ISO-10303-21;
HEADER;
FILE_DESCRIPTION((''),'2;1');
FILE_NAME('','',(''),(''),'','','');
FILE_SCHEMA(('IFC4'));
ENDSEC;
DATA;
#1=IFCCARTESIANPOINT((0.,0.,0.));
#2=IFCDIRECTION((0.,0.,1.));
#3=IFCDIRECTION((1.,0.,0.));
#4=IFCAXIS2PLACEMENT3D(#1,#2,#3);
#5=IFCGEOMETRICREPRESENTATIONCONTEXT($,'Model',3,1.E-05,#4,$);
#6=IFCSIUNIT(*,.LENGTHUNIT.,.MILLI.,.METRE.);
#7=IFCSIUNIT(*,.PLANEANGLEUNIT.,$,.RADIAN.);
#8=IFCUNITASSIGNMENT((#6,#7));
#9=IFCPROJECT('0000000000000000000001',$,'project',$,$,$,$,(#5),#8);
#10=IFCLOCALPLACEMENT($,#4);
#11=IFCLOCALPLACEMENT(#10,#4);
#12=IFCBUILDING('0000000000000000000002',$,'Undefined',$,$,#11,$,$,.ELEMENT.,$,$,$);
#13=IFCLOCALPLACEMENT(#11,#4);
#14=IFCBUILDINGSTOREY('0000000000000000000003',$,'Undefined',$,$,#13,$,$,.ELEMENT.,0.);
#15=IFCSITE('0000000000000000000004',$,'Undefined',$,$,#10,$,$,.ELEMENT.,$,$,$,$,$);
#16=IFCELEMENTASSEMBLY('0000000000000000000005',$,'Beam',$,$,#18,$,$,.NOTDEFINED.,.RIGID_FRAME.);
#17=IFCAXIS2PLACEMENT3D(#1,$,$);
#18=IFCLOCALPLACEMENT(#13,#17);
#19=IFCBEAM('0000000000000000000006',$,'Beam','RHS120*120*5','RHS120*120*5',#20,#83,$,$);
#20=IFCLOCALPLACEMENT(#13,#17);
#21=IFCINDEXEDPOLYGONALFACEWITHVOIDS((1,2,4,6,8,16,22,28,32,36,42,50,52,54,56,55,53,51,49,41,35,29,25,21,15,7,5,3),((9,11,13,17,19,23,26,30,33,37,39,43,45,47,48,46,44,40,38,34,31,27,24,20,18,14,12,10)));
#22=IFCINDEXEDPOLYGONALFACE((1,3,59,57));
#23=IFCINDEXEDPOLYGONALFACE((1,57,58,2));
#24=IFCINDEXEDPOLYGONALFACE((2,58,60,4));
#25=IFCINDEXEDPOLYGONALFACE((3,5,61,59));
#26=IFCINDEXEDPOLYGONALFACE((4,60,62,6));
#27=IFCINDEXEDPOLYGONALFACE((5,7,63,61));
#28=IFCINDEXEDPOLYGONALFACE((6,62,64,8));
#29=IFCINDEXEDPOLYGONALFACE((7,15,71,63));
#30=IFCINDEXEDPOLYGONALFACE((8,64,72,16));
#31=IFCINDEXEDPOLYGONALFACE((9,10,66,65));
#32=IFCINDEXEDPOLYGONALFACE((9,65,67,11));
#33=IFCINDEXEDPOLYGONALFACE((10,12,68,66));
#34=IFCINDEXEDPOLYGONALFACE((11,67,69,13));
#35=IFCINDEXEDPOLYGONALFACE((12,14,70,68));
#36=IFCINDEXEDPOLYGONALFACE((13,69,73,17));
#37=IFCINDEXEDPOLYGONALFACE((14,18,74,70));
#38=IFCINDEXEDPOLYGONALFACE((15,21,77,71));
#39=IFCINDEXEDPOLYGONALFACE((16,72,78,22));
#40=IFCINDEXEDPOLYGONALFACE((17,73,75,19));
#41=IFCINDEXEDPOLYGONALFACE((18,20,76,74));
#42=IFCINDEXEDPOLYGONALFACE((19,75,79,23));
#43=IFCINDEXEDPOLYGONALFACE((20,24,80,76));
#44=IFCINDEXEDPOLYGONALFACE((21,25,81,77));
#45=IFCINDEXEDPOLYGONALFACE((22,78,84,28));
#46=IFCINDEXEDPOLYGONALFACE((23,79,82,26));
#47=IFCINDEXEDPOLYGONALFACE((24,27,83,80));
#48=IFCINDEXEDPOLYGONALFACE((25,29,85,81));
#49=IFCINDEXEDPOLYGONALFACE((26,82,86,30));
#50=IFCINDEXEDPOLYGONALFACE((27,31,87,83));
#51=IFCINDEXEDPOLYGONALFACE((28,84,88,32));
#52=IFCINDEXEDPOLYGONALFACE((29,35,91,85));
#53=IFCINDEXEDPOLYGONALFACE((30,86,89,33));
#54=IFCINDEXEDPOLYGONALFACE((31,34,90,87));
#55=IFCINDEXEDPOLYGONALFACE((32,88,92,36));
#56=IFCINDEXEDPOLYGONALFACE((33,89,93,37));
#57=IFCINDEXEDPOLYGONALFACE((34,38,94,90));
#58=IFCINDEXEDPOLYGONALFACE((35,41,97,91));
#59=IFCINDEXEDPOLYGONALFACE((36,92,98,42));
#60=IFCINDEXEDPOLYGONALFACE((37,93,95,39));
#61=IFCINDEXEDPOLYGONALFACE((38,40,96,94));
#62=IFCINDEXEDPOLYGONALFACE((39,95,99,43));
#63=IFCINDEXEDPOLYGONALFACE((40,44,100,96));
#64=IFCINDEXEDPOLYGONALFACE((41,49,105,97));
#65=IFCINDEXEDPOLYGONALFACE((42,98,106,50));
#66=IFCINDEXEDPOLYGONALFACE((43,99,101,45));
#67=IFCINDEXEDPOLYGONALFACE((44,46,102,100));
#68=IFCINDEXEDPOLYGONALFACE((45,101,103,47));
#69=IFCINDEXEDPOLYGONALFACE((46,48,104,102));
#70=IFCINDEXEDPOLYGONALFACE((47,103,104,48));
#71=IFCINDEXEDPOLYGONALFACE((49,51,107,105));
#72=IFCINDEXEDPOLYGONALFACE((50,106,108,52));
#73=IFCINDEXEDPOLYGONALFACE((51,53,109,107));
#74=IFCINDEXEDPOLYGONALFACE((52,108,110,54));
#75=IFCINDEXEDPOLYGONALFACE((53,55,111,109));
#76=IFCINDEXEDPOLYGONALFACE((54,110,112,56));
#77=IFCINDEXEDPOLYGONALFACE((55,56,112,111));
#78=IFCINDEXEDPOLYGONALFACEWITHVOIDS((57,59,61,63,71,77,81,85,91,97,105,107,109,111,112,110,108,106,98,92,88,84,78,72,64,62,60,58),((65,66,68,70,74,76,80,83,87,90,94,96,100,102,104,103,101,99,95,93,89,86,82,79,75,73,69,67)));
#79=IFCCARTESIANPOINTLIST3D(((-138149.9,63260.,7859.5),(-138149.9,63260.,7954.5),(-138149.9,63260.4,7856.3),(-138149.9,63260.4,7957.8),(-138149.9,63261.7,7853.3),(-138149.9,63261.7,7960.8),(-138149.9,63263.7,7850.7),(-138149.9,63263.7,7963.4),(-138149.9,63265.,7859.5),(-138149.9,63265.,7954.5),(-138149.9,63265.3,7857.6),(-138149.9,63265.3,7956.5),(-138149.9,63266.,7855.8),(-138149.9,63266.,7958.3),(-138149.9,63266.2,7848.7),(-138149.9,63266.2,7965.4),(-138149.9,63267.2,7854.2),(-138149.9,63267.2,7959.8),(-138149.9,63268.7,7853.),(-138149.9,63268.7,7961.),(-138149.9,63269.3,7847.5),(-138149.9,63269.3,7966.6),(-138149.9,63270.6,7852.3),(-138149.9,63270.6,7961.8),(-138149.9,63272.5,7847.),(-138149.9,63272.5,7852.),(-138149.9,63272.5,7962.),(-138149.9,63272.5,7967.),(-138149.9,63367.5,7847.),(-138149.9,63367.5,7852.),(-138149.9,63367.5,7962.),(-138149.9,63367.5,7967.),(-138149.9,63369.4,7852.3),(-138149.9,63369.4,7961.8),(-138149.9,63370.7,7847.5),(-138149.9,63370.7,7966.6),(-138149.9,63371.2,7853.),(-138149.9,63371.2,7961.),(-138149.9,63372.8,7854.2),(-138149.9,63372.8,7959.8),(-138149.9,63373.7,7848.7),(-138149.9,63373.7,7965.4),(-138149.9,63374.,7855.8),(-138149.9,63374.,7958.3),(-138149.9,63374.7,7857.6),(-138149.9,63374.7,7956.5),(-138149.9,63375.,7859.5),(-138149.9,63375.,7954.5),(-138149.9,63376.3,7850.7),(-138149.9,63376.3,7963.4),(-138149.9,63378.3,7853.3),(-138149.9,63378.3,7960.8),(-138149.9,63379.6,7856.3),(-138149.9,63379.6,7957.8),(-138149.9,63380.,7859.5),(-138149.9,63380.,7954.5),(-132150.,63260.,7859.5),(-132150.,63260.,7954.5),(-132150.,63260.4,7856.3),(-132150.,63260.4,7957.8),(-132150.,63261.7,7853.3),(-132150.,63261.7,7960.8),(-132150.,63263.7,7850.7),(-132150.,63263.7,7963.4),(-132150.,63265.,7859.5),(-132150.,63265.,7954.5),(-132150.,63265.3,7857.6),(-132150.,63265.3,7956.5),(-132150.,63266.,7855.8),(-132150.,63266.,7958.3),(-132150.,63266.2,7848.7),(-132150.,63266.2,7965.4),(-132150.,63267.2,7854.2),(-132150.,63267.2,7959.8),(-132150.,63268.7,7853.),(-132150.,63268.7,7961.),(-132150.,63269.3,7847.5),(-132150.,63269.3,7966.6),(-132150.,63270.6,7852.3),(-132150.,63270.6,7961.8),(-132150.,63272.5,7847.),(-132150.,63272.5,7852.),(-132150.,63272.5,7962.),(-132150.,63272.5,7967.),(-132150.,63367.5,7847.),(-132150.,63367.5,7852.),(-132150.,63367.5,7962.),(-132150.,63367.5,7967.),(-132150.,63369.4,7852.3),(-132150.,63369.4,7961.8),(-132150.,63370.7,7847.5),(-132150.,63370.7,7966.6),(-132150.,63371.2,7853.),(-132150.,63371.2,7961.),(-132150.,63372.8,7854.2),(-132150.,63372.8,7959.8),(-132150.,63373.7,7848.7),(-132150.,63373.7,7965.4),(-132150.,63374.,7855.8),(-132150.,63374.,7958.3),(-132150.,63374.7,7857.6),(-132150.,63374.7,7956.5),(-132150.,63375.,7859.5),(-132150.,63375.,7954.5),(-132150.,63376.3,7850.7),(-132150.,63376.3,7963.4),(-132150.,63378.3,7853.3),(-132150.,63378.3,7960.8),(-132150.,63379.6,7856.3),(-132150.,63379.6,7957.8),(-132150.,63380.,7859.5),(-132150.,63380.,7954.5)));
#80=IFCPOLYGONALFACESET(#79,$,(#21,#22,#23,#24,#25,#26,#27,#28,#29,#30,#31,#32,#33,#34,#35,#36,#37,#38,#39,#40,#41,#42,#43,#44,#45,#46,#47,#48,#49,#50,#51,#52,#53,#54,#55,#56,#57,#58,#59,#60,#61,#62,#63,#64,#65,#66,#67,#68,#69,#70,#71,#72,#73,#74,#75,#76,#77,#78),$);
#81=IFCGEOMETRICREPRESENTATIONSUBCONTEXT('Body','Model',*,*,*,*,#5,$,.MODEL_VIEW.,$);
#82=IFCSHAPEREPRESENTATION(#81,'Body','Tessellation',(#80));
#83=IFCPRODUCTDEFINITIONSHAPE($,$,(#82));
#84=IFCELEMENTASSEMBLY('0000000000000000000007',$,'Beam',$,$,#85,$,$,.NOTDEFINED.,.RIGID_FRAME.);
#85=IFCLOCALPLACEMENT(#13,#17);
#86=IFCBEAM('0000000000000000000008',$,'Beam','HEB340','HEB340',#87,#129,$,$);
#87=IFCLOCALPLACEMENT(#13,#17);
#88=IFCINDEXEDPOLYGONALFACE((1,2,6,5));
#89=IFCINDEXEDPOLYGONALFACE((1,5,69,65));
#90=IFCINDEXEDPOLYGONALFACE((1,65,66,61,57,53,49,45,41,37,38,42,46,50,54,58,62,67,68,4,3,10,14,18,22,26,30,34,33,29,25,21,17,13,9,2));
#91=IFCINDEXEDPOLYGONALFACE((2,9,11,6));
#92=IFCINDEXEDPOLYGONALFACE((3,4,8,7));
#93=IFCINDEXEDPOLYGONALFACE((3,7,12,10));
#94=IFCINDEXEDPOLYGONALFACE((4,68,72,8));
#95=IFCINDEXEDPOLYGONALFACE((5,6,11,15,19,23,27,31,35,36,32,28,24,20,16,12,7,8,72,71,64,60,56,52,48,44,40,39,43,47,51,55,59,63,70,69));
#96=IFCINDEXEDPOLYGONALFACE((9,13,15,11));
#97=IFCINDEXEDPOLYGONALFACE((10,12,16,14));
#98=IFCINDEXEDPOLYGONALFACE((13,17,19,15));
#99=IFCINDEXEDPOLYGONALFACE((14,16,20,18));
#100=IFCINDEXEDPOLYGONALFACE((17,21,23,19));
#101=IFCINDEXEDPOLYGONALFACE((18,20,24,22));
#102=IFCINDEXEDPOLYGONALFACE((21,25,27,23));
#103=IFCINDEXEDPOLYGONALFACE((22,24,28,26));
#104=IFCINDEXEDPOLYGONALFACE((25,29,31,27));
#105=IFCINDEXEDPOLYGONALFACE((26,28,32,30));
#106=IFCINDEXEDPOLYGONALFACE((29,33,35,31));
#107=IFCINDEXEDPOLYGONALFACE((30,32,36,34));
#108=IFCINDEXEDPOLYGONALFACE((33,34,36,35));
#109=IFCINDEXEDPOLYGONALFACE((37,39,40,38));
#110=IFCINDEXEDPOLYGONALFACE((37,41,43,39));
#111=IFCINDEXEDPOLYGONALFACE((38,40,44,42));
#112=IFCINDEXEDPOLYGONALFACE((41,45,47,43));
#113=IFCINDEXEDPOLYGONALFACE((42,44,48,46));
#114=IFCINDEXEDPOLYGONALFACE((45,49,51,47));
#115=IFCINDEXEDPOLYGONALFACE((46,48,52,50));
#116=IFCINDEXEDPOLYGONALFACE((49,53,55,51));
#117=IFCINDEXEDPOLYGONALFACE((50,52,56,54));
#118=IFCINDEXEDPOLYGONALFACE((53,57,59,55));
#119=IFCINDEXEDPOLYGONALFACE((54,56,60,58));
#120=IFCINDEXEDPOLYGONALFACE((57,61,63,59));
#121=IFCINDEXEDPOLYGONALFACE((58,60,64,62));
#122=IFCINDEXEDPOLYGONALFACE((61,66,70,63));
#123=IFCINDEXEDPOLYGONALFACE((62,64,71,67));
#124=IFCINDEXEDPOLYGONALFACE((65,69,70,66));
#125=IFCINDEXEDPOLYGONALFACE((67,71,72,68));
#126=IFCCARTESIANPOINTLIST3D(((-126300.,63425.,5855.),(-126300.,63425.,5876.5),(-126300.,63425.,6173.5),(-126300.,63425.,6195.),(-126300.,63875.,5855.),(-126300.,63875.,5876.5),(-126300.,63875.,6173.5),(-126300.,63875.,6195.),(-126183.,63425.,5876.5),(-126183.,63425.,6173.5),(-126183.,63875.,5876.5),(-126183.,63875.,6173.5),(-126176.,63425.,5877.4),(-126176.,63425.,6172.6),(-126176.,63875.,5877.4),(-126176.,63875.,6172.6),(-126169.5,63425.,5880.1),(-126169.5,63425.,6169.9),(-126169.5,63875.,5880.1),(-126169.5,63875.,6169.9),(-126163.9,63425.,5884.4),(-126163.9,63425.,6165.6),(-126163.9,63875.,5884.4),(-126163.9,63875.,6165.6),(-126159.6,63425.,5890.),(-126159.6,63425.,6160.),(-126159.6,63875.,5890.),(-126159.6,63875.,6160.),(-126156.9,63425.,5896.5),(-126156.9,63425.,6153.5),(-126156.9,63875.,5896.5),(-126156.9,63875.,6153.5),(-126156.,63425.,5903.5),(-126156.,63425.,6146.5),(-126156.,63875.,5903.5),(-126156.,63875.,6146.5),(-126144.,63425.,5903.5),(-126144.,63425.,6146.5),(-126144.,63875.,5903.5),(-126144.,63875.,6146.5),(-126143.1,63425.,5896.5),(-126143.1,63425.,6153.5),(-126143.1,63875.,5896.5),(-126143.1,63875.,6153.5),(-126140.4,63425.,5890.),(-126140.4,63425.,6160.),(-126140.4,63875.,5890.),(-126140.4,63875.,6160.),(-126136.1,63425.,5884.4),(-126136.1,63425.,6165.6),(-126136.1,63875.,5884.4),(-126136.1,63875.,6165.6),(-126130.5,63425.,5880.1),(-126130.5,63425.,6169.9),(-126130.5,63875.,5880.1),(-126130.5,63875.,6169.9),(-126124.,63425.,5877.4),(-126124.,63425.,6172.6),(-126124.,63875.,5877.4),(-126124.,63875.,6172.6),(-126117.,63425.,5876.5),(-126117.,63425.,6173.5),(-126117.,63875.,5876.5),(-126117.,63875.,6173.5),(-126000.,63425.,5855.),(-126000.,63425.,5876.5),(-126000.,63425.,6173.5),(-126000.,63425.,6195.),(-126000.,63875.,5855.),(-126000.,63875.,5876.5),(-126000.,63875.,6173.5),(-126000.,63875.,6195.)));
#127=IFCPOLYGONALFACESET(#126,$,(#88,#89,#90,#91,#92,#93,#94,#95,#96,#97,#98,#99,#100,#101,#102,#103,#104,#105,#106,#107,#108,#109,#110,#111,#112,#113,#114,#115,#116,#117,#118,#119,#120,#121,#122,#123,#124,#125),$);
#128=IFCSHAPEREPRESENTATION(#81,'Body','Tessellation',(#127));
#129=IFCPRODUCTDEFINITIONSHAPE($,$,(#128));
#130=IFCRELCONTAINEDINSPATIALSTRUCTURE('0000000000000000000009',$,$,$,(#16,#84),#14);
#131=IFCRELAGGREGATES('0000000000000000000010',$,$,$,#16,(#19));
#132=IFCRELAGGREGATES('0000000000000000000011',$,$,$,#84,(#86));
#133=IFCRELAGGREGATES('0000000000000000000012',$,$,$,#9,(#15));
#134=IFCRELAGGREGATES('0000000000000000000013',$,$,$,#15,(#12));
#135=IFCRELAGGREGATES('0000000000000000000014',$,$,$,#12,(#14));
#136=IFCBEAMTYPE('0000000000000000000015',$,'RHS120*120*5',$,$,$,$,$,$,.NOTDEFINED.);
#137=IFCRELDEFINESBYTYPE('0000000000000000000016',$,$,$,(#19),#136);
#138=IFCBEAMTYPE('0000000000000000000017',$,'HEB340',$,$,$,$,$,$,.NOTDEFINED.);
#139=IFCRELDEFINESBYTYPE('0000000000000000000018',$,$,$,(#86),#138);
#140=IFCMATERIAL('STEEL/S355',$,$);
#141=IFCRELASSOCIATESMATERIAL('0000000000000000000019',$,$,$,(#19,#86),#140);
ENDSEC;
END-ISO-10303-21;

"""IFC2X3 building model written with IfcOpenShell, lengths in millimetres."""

from ifc_helpers import new_model, si_unit, frame, origin_with_axes, origin_2d_with_axis, place, context, subcontext, project, spatial, hollow_rectangle, i_section, extrude, material, type_object, element, aggregate, save


model = new_model("IFC2X3")

# Units and contexts
model_context = context("Model", 3, precision=1e-05, world=origin_with_axes())
body_context = subcontext(model_context, "Body", "Model", "MODEL_VIEW")
ifc_project = project(units=[si_unit("LENGTHUNIT", "METRE", prefix="MILLI"), si_unit("PLANEANGLEUNIT", "RADIAN")], contexts=[model_context])

# Site, building, storey
site_placement = place(None, origin_with_axes())
site = spatial("IfcSite", under=ifc_project, at=site_placement, Name="Undefined", CompositionType="ELEMENT")
building_placement = place(site_placement, origin_with_axes())
building = spatial("IfcBuilding", under=site, at=building_placement, Name="Undefined", CompositionType="ELEMENT")
storey_placement = place(building_placement, origin_with_axes())
storey = spatial("IfcBuildingStorey", under=building, at=storey_placement, Name="Undefined", CompositionType="ELEMENT", Elevation=0.0)

# Shared definitions
ifc_material_1 = material(Name="STEEL/S355")

# Element assemblies, beams
assembly_1_placement = place(storey_placement, origin_with_axes())
assembly_1 = element("IfcElementAssembly", 1, at=assembly_1_placement, inside=storey, Name="Beam", AssemblyPlace="NOTDEFINED", PredefinedType="RIGID_FRAME")
beam_type_1 = type_object("IfcBeamType", Name="RHS120*120*5", PredefinedType="NOTDEFINED")
beam_1_placement = place(assembly_1_placement, frame((-132150.0, 63320.0, 7907.0), z_axis=(0.0, 0.0, 1.0), x_axis=(-1.0, 0.0, 0.0)))
beam_1 = element("IfcBeam", 2, at=beam_1_placement, type_object=beam_type_1, material=ifc_material_1, Name="Beam", Description="RHS120*120*5", ObjectType="RHS120*120*5", context=body_context, shape_type="SweptSolid", body=[
    extrude(hollow_rectangle(XDim=120.0, YDim=120.0, WallThickness=5.0, InnerFilletRadius=7.5, OuterFilletRadius=12.5, at=origin_2d_with_axis()), frame((5999.9, 0.0, 0.0), z_axis=(-1.0, 0.0, 0.0), x_axis=(0.0, -1.0, 0.0)), (0.0, 0.0, 1.0), 5999.9),
])
aggregate(assembly_1, [beam_1])
assembly_2_placement = place(storey_placement, origin_with_axes())
assembly_2 = element("IfcElementAssembly", 3, at=assembly_2_placement, inside=storey, Name="Beam", AssemblyPlace="NOTDEFINED", PredefinedType="RIGID_FRAME")
beam_type_2 = type_object("IfcBeamType", Name="HEB340", PredefinedType="NOTDEFINED")
beam_2_placement = place(assembly_2_placement, frame((-126150.0, 63875.0, 6025.0), z_axis=(0.0, 0.0, 1.0), x_axis=(0.0, -1.0, 0.0)))
beam_2 = element("IfcBeam", 4, at=beam_2_placement, type_object=beam_type_2, material=ifc_material_1, Name="Beam", Description="HEB340", ObjectType="HEB340", context=body_context, shape_type="SweptSolid", body=[
    extrude(i_section(OverallWidth=300.0, OverallDepth=340.0, WebThickness=12.0, FlangeThickness=21.5, FilletRadius=27.0, at=origin_2d_with_axis()), frame((450.0, 0.0, 0.0), z_axis=(-1.0, 0.0, 0.0), x_axis=(0.0, -1.0, 0.0)), (0.0, 0.0, 1.0), 450.0),
])
aggregate(assembly_2, [beam_2])

save(model, "model.ifc")
